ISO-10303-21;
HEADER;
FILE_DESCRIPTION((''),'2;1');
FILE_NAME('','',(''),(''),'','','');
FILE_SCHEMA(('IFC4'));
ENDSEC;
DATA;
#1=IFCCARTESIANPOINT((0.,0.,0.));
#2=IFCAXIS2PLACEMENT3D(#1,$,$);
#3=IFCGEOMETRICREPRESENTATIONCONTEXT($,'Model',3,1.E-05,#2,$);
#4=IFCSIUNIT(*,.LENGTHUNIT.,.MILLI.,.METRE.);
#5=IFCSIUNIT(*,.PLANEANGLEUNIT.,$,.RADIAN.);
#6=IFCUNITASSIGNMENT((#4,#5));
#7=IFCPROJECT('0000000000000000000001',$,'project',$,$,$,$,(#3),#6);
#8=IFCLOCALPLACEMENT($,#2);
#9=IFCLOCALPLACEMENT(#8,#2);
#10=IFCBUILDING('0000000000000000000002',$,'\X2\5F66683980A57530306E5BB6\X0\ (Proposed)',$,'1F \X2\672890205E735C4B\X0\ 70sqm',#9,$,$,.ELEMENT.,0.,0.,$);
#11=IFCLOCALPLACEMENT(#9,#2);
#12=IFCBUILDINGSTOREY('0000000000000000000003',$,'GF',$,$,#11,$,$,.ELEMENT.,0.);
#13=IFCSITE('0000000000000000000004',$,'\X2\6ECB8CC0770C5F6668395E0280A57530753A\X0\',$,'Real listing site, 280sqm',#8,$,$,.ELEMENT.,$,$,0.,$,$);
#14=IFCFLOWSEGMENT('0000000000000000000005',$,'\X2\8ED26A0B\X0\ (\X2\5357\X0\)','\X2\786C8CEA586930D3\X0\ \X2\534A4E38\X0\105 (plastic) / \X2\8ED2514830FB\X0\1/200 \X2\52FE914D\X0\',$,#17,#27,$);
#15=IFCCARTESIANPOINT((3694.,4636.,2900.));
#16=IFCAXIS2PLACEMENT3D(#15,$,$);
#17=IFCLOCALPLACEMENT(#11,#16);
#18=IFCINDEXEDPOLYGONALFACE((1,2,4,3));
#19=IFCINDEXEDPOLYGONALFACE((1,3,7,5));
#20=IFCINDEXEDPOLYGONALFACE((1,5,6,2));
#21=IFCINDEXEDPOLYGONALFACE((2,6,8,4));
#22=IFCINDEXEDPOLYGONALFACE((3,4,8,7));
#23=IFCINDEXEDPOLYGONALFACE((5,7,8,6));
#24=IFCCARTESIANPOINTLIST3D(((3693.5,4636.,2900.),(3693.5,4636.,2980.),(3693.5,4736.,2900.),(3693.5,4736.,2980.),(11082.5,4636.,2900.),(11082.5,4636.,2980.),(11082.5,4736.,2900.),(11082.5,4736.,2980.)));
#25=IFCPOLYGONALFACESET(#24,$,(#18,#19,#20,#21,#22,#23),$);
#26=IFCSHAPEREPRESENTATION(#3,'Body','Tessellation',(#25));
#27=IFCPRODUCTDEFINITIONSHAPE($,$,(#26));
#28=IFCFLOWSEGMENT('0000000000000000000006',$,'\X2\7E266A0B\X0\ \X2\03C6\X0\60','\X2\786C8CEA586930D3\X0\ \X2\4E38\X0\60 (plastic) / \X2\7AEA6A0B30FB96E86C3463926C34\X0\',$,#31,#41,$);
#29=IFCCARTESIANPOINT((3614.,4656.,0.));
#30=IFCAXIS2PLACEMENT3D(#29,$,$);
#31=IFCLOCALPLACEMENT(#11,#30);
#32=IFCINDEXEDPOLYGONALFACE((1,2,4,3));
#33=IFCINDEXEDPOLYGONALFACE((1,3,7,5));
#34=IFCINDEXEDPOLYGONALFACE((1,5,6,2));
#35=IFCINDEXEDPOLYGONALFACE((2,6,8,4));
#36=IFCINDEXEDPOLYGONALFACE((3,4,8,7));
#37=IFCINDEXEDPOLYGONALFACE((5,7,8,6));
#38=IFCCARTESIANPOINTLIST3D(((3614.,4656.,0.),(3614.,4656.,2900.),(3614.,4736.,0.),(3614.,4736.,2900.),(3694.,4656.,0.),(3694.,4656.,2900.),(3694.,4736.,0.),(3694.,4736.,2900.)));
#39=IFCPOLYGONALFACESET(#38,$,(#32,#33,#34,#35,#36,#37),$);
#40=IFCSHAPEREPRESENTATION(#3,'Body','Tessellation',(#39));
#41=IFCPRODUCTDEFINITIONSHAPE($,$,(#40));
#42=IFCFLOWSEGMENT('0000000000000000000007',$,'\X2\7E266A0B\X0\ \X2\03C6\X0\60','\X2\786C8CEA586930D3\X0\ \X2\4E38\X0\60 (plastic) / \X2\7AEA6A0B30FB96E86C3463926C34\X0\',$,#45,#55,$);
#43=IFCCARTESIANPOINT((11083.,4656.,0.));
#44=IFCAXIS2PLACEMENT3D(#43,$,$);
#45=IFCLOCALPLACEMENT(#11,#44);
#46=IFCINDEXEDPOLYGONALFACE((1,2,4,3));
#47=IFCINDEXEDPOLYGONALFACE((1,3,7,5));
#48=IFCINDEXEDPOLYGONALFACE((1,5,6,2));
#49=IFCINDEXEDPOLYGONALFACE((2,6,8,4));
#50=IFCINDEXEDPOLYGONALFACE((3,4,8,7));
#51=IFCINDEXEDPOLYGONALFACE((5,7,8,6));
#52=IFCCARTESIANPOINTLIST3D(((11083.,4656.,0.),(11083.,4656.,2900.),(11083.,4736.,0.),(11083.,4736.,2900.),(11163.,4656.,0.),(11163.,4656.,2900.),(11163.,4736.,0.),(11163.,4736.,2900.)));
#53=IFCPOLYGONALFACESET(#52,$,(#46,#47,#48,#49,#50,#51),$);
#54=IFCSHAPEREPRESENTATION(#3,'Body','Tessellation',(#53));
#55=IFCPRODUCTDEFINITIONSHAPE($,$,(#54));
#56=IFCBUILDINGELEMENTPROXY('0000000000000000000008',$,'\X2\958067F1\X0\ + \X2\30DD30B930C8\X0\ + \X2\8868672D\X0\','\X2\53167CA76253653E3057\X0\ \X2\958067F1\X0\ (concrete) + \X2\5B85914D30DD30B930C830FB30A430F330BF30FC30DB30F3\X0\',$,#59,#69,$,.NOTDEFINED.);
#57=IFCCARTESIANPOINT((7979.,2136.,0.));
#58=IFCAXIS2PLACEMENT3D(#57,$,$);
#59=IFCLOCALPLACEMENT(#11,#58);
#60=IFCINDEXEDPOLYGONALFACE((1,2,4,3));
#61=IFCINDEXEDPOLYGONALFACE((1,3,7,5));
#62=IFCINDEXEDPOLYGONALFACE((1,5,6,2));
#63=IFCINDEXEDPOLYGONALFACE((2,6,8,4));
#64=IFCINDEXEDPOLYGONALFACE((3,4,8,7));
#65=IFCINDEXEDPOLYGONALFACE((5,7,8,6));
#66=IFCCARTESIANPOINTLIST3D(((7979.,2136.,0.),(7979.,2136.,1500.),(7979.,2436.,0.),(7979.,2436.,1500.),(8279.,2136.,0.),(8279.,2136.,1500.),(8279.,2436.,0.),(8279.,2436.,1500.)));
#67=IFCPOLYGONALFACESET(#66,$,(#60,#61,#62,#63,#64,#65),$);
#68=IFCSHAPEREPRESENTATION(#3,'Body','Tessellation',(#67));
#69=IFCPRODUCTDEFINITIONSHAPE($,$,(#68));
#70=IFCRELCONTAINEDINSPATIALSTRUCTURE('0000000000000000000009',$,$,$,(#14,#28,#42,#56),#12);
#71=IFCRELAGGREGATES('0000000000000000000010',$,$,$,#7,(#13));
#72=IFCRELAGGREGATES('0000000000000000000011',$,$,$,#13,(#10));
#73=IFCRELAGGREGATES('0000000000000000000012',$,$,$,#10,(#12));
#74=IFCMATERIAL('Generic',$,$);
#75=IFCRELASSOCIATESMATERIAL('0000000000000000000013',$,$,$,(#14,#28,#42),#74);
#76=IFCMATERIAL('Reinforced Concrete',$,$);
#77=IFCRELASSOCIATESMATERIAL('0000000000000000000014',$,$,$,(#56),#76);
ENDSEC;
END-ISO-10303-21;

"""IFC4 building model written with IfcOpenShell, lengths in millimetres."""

from ifc_helpers import new_model, si_unit, frame, frame_2d, origin, place, context, project, spatial, rectangle, extrude, material, element, save


model = new_model("IFC4")

# Units and contexts
model_context = context("Model", 3, precision=1e-05, world=origin())
ifc_project = project(units=[si_unit("LENGTHUNIT", "METRE", prefix="MILLI"), si_unit("PLANEANGLEUNIT", "RADIAN")], contexts=[model_context])

# Site, building, storey
site_placement = place(None, origin())
site = spatial("IfcSite", under=ifc_project, at=site_placement, Name="滋賀県彦根市肥田町", ObjectType="Real listing site, 280sqm", CompositionType="ELEMENT", RefElevation=0.0)
building_placement = place(site_placement, origin())
building = spatial("IfcBuilding", under=site, at=building_placement, Name="彦根肥田の家 (Proposed)", ObjectType="1F 木造平屋 70sqm", CompositionType="ELEMENT", ElevationOfRefHeight=0.0, ElevationOfTerrain=0.0)
storey_placement = place(building_placement, origin())
storey = spatial("IfcBuildingStorey", under=building, at=storey_placement, Name="GF", CompositionType="ELEMENT", Elevation=0.0)

# Shared definitions
ifc_material_1 = material(Name="Reinforced Concrete")

# Shared definitions
ifc_material_2 = material(Name="Generic")

# Flow segments
flow_segment_1_placement = place(storey_placement, frame((3694.0, 4636.0, 2900.0)))
element("IfcFlowSegment", 1, at=flow_segment_1_placement, inside=storey, material=ifc_material_2, Name="軒樋 (南)", Description="硬質塩ビ 半丸105 (plastic) / 軒先・1/200 勾配", context=model_context, shape_type="SweptSolid", body=[
    extrude(rectangle(XDim=7389.0, YDim=100.0, at=frame_2d((3694.0, 50.0))), frame((3694.0, 4636.0, 2900.0)), (0.0, 0.0, 1.0), 80.0),
])
flow_segment_2_placement = place(storey_placement, frame((3614.0, 4656.0, 0.0)))
element("IfcFlowSegment", 2, at=flow_segment_2_placement, inside=storey, material=ifc_material_2, Name="縦樋 φ60", Description="硬質塩ビ 丸60 (plastic) / 竪樋・雨水排水", context=model_context, shape_type="SweptSolid", body=[
    extrude(rectangle(XDim=80.0, YDim=80.0, at=frame_2d((40.0, 40.0))), frame((3614.0, 4656.0, 0.0)), (0.0, 0.0, 1.0), 2900.0),
])
flow_segment_3_placement = place(storey_placement, frame((11083.0, 4656.0, 0.0)))
element("IfcFlowSegment", 3, at=flow_segment_3_placement, inside=storey, material=ifc_material_2, Name="縦樋 φ60", Description="硬質塩ビ 丸60 (plastic) / 竪樋・雨水排水", context=model_context, shape_type="SweptSolid", body=[
    extrude(rectangle(XDim=80.0, YDim=80.0, at=frame_2d((40.0, 40.0))), frame((11083.0, 4656.0, 0.0)), (0.0, 0.0, 1.0), 2900.0),
])

# Building element proxy
proxy_placement = place(storey_placement, frame((7979.0, 2136.0, 0.0)))
element("IfcBuildingElementProxy", 4, at=proxy_placement, inside=storey, material=ifc_material_1, Name="門柱 + ポスト + 表札", Description="化粧打放し 門柱 (concrete) + 宅配ポスト・インターホン", PredefinedType="NOTDEFINED", context=model_context, shape_type="SweptSolid", body=[
    extrude(rectangle(XDim=300.0, YDim=300.0, at=frame_2d((150.0, 150.0))), frame((7979.0, 2136.0, 0.0)), (0.0, 0.0, 1.0), 1500.0),
])

save(model, "model.ifc")
